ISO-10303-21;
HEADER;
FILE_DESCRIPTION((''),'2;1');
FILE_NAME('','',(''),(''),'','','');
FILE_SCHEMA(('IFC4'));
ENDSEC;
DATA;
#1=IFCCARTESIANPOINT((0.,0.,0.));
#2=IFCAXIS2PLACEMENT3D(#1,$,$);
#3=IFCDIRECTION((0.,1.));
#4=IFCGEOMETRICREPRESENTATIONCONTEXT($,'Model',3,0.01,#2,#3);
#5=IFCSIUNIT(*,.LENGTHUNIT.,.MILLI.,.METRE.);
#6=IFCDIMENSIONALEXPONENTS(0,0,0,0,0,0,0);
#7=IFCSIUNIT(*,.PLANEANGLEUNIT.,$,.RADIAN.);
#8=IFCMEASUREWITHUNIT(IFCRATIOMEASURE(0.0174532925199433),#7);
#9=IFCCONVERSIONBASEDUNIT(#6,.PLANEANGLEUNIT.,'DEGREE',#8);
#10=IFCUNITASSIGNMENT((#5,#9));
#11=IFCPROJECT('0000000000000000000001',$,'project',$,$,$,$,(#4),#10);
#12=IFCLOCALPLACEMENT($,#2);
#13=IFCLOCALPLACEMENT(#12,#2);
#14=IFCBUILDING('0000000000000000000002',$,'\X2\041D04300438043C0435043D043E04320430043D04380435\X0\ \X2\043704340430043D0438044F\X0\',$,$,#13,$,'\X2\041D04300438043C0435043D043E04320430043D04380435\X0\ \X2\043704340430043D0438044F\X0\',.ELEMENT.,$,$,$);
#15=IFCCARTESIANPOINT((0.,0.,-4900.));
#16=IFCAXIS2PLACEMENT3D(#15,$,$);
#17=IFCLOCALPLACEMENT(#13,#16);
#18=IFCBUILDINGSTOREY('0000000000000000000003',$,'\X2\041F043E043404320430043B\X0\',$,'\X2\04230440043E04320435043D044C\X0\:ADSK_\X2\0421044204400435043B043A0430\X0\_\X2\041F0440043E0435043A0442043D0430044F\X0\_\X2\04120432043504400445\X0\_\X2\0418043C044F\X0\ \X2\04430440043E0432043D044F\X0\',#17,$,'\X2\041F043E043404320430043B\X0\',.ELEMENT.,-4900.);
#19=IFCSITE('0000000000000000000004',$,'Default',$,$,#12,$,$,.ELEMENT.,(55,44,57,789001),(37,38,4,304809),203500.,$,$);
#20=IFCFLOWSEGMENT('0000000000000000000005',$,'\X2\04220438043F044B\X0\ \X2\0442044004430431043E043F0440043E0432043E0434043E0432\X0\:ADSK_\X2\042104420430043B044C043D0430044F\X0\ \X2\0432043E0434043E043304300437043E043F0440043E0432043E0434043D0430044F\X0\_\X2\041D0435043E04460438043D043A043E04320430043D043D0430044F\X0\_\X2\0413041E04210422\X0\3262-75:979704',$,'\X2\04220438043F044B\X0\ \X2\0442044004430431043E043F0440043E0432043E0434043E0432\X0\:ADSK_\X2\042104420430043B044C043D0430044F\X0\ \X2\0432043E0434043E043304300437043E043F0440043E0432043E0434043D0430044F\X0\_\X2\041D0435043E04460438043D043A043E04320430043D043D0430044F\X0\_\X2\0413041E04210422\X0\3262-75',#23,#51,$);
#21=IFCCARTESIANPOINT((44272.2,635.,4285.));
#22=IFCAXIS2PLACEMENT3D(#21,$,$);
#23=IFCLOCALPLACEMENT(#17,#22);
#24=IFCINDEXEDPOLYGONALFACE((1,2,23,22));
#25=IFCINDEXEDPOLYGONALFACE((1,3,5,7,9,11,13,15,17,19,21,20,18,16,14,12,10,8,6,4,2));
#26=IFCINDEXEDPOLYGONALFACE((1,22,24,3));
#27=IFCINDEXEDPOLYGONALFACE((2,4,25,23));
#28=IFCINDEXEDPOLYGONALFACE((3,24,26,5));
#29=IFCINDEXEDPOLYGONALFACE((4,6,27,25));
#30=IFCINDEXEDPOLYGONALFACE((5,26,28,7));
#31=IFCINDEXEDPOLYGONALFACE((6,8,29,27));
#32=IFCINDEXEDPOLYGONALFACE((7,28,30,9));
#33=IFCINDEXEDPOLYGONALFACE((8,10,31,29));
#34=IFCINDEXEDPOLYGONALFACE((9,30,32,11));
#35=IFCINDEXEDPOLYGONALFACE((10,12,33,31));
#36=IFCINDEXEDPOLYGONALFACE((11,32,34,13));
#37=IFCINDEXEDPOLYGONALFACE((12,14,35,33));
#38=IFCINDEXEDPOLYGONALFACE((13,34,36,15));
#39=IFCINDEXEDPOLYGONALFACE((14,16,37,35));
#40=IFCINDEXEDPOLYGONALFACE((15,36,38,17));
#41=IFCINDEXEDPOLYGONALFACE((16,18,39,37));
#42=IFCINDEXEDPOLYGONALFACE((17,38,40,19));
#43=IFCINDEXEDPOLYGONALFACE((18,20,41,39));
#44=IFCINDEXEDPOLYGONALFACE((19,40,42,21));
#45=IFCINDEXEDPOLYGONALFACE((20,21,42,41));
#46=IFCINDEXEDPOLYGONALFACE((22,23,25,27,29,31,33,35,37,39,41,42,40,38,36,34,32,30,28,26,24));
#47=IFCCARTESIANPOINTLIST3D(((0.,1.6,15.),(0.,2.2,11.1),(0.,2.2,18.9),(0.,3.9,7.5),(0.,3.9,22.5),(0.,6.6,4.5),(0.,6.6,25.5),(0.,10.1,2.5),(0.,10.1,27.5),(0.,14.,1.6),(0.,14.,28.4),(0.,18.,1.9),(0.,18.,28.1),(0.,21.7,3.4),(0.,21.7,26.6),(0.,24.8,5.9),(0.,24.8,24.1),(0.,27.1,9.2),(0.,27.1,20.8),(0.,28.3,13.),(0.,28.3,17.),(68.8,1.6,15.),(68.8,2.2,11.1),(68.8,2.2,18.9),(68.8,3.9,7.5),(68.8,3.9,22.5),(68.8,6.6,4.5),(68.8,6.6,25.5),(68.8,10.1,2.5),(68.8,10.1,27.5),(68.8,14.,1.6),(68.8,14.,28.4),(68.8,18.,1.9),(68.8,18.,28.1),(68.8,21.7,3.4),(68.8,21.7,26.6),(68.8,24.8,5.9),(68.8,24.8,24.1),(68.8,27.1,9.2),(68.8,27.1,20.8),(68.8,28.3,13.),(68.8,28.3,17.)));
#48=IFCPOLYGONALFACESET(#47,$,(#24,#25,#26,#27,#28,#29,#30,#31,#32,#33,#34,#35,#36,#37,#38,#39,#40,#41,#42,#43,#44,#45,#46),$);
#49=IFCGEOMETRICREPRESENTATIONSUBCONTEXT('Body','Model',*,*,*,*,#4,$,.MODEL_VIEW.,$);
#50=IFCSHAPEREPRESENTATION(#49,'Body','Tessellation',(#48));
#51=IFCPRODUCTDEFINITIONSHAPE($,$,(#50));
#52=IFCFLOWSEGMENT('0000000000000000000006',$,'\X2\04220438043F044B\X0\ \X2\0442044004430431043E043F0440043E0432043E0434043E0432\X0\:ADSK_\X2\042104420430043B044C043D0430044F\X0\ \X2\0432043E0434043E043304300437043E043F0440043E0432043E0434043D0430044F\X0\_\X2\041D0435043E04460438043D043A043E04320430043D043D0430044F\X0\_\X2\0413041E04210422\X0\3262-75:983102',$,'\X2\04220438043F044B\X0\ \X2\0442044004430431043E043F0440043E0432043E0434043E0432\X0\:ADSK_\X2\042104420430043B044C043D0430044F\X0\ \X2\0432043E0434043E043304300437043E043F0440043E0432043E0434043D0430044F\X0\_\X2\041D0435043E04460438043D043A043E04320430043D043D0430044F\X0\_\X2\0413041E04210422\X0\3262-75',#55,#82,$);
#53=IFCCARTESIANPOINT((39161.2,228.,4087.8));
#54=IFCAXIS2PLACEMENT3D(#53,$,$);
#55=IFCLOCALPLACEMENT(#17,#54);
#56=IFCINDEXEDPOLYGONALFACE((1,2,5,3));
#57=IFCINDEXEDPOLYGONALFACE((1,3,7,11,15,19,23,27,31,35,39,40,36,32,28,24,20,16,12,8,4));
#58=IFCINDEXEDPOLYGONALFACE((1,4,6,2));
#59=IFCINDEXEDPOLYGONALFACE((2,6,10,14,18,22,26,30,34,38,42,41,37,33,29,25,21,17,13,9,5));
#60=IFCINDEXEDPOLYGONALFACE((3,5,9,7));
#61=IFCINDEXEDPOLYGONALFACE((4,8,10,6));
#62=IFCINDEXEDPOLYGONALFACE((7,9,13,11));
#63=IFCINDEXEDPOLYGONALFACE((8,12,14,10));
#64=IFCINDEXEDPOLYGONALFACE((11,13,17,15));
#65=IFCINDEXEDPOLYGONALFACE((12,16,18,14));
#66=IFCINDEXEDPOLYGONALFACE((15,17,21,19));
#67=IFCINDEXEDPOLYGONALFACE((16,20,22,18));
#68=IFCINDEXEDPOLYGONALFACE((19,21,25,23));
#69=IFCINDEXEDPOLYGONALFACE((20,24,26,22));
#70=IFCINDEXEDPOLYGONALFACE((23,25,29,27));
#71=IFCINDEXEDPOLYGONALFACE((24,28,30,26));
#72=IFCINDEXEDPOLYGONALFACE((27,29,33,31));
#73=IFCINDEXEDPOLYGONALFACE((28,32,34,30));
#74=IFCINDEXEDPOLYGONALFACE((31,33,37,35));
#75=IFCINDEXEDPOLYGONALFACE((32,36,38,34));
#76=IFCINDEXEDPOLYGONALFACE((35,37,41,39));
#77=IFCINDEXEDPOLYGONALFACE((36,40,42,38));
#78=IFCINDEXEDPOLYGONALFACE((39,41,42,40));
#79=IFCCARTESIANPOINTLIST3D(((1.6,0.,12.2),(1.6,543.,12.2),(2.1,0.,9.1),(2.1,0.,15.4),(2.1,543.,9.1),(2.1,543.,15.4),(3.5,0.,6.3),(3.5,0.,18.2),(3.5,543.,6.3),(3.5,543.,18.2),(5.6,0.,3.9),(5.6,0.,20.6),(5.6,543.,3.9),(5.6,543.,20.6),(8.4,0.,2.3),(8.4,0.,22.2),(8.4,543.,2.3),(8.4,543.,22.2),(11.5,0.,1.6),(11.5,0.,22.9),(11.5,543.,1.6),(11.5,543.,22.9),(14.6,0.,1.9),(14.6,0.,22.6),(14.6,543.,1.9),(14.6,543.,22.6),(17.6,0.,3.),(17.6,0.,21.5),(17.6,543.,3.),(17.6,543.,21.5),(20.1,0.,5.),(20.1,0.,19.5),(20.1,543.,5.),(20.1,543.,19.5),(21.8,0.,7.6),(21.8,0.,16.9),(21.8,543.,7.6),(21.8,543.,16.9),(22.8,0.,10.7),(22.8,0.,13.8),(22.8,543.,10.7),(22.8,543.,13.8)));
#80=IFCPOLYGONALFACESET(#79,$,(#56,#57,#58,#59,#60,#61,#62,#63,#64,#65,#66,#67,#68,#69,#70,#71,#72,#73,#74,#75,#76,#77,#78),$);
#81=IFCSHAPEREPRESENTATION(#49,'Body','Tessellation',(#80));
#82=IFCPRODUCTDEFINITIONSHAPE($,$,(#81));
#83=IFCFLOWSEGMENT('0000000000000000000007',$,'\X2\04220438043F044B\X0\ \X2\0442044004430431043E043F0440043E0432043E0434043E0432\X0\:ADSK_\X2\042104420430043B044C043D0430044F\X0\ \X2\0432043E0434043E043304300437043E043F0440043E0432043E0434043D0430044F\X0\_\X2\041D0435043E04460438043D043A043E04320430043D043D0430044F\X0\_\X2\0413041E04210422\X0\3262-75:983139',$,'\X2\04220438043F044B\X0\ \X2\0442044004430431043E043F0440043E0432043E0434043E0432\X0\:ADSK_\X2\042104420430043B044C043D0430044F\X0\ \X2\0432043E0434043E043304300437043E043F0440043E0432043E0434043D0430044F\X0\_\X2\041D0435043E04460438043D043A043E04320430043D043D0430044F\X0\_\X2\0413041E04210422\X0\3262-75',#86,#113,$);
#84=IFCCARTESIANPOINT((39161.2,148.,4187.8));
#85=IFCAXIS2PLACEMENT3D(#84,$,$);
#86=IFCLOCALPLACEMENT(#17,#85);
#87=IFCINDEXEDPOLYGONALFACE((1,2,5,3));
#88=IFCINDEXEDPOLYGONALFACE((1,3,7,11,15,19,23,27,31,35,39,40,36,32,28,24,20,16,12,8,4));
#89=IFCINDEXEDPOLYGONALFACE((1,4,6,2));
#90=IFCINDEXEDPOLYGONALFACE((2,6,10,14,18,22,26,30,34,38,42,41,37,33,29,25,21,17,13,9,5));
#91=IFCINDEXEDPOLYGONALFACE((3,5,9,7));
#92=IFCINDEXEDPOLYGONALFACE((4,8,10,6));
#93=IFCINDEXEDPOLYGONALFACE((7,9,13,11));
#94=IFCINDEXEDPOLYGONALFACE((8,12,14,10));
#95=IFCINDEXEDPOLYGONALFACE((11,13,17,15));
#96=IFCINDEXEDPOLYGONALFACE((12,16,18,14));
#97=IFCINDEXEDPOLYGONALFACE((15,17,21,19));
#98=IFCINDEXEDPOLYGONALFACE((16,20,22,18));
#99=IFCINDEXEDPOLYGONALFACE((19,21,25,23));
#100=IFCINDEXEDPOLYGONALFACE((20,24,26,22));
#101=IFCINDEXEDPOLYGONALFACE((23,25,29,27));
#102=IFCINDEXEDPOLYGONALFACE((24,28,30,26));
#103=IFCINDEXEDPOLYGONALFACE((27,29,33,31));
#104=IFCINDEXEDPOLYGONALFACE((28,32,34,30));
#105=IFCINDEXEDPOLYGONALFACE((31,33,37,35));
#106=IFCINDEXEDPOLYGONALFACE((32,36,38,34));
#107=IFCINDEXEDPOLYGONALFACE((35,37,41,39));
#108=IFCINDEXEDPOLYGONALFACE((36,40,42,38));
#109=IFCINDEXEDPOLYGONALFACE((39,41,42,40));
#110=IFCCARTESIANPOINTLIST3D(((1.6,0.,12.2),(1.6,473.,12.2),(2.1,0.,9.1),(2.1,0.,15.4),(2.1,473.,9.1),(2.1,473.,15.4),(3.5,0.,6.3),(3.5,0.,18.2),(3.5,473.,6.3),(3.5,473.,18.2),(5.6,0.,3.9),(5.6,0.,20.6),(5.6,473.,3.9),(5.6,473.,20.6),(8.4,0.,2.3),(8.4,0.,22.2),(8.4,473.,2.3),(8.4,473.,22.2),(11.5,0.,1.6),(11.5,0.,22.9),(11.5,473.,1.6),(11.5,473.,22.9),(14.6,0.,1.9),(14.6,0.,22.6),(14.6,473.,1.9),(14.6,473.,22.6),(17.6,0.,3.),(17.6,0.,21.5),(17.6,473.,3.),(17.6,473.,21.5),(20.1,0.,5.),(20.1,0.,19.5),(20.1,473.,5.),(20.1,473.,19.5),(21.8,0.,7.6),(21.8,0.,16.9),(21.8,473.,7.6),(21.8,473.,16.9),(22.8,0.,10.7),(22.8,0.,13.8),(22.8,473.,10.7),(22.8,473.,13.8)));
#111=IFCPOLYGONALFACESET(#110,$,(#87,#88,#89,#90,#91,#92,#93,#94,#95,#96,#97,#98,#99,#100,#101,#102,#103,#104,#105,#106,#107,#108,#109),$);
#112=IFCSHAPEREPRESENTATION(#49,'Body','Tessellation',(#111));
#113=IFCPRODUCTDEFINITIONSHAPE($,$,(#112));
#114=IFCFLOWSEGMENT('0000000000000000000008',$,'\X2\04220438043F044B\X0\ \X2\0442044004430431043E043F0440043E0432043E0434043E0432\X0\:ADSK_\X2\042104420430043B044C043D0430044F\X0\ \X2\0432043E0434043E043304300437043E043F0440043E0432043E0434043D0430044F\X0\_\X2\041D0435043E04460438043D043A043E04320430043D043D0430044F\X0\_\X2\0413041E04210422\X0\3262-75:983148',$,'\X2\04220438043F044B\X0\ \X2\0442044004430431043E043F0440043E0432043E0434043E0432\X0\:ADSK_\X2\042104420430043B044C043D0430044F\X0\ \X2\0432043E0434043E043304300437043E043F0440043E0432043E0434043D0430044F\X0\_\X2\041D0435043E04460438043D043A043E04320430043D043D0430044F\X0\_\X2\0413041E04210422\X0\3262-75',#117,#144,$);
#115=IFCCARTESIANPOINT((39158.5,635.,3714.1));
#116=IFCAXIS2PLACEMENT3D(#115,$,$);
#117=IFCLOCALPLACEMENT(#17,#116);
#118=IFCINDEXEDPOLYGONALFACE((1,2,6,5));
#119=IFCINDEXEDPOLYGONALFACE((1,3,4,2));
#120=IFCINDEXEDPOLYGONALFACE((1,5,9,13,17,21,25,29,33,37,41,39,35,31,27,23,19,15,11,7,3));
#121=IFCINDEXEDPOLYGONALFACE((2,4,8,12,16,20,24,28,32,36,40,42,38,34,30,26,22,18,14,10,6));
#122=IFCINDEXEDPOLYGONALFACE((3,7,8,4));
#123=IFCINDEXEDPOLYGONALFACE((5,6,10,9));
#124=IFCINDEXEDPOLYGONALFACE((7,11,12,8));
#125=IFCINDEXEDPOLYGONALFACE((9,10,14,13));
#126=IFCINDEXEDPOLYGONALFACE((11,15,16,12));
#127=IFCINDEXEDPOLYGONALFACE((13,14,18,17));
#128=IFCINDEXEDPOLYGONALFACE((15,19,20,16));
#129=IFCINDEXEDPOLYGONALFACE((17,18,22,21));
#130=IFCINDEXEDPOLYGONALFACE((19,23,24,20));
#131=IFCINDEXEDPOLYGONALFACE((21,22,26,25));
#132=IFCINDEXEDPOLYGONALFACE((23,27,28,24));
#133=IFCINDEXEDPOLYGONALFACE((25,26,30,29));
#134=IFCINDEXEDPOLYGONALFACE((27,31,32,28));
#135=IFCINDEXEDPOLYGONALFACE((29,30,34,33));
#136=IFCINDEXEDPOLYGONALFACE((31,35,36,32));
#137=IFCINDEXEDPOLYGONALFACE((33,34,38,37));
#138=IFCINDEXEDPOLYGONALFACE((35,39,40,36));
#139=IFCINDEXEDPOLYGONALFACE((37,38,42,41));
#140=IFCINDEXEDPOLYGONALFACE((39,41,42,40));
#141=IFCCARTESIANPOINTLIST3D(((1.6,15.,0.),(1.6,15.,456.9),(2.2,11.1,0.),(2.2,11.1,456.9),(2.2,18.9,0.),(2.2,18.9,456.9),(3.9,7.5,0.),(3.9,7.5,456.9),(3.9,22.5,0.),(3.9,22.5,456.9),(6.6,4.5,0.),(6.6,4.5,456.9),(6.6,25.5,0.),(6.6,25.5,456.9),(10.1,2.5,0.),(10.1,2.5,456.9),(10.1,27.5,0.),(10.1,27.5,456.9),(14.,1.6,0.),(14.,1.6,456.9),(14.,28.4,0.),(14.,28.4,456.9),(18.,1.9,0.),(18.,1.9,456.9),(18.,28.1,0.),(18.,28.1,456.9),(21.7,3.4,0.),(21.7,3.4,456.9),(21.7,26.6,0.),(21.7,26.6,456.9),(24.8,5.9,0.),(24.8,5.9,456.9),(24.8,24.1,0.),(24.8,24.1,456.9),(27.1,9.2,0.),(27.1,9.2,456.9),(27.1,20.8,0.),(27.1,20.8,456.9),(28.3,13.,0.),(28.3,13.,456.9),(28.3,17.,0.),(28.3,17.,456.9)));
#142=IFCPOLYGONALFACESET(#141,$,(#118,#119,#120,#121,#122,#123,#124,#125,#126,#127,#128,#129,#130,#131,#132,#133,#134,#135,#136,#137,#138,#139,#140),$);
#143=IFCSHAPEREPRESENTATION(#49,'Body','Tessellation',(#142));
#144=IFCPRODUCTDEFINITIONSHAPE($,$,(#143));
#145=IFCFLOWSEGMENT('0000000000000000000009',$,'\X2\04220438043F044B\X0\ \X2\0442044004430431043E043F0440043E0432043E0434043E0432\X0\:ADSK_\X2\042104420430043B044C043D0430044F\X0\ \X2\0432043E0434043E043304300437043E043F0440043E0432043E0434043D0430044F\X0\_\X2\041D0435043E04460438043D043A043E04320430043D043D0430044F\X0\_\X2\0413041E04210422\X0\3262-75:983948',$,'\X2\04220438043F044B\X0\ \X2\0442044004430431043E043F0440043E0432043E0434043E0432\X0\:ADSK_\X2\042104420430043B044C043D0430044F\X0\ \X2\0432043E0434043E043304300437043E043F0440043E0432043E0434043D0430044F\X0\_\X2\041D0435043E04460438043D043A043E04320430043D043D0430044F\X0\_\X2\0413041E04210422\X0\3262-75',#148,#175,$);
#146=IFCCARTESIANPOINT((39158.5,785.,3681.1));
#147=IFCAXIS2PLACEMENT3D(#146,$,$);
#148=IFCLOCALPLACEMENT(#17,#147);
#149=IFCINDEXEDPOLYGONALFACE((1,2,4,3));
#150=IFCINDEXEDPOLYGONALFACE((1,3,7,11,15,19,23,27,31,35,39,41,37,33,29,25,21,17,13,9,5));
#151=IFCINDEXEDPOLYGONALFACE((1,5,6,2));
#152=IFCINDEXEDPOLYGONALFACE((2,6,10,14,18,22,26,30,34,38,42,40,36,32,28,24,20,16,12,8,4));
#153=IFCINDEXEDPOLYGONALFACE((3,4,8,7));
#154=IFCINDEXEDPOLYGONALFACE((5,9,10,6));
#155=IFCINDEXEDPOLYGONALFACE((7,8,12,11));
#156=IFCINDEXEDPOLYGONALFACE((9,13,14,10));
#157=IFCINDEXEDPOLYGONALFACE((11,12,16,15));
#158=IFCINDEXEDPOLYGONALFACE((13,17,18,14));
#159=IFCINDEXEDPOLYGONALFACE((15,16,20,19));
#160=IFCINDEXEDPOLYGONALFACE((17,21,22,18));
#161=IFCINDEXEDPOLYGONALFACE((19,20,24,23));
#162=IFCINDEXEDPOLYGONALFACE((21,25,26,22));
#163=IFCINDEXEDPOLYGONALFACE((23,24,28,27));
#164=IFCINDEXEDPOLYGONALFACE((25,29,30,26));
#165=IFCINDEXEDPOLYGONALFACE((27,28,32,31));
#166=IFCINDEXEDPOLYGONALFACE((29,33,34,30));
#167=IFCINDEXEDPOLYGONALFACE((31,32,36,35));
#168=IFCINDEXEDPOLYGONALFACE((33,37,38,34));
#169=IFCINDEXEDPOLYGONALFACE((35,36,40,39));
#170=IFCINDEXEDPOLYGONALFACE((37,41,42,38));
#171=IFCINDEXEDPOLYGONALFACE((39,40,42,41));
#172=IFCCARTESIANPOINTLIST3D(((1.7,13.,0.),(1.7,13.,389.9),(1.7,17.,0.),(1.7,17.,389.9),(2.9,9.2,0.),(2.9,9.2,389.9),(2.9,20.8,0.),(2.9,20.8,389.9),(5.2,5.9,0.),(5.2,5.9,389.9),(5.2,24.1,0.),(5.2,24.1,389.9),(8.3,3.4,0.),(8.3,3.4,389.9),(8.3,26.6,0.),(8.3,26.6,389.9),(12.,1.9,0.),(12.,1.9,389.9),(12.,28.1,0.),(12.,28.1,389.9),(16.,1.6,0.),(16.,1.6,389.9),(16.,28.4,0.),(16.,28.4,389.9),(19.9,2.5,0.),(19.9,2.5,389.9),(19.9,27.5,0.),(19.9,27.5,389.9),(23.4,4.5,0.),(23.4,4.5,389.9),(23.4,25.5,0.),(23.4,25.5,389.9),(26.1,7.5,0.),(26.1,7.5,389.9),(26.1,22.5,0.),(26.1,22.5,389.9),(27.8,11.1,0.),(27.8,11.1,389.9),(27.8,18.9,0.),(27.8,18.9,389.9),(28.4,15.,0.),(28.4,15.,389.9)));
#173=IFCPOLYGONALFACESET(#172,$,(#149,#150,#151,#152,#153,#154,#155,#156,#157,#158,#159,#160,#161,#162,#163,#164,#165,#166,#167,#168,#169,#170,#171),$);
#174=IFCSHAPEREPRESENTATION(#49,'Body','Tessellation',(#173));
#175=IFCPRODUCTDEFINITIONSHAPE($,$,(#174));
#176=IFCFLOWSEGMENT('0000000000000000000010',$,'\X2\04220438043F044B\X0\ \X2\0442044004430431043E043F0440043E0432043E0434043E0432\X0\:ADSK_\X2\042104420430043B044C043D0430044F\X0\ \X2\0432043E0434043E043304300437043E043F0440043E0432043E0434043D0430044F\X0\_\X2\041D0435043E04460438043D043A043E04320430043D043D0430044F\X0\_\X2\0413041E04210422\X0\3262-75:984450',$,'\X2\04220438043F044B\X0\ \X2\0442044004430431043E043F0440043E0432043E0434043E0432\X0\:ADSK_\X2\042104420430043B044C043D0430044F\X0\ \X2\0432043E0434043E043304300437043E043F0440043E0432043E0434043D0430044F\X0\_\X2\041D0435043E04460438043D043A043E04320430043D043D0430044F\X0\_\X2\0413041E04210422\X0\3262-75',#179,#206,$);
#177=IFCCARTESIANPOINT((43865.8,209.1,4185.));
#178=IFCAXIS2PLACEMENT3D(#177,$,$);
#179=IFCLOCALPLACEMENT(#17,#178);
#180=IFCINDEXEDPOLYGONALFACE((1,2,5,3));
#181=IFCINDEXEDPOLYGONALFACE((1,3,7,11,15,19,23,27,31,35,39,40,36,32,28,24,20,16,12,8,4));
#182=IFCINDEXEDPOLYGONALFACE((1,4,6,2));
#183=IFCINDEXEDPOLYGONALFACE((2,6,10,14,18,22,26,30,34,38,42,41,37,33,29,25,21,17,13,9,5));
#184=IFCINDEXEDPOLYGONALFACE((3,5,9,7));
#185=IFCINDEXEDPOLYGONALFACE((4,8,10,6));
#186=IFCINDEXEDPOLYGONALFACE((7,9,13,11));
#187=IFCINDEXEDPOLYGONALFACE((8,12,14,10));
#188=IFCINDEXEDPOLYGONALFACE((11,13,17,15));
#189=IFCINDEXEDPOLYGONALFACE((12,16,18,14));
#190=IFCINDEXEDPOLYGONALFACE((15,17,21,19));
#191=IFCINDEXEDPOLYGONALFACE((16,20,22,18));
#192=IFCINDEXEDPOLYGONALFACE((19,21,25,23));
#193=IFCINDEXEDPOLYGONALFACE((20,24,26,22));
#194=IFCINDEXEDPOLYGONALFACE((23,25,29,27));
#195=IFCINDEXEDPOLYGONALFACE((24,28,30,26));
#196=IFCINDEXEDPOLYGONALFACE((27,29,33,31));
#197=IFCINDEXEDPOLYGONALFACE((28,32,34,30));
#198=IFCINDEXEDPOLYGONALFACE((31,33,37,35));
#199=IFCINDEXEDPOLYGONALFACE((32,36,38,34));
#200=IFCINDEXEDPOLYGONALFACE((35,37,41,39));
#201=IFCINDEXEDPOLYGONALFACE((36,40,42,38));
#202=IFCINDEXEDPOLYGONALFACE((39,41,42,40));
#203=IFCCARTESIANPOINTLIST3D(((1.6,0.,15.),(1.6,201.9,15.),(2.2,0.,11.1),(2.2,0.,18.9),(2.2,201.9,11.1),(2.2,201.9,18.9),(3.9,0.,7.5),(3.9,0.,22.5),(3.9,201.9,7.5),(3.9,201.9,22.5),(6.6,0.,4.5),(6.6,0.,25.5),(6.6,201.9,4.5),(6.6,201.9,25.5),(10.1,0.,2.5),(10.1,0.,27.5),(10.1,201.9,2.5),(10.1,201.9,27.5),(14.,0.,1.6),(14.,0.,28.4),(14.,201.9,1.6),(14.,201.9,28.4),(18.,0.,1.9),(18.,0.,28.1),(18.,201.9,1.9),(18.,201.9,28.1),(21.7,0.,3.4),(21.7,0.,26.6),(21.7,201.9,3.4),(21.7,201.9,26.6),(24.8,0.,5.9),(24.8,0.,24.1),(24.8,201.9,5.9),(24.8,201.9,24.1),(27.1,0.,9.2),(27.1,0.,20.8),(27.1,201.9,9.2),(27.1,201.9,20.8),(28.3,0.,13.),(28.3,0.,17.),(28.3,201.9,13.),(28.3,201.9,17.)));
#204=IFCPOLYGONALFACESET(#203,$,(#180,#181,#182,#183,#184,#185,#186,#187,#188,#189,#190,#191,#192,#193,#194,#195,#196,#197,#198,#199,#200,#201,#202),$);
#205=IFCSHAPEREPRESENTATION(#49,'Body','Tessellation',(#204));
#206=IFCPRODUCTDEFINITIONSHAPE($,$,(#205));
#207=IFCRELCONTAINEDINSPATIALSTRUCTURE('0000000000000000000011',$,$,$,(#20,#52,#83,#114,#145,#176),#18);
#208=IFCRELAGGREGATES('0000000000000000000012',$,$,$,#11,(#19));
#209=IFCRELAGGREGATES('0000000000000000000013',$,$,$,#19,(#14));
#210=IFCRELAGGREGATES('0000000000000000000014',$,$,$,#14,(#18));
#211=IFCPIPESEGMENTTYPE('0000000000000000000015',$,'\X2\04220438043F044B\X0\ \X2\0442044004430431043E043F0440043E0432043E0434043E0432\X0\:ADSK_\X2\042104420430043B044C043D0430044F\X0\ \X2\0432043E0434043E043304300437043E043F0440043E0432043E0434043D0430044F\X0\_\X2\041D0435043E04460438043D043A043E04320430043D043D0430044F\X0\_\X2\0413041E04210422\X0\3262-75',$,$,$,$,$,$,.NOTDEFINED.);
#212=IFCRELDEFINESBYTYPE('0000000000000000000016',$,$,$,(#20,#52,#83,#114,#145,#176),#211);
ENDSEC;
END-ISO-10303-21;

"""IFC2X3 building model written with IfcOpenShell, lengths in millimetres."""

from ifc_helpers import new_model, entity, si_unit, converted_unit, direction, frame, origin, origin_2d_with_axis, place, context, subcontext, project, spatial, circle, extrude, type_object, element, save


model = new_model("IFC2X3")

# Units and contexts
model_context = context("Model", 3, precision=0.01, world=origin(), true_north=direction((0.0, 1.0)))
body_context = subcontext(model_context, "Body", "Model", "MODEL_VIEW")
ifc_project = project(units=[si_unit("LENGTHUNIT", "METRE", prefix="MILLI"), converted_unit("PLANEANGLEUNIT", "DEGREE", entity("IfcRatioMeasure", 0.0174532925199433), si_unit("PLANEANGLEUNIT", "RADIAN"), dimensions=[0, 0, 0, 0, 0, 0, 0])], contexts=[model_context])

# Site, building, storey
site_placement = place(None, origin())
site = spatial("IfcSite", under=ifc_project, at=site_placement, Name="Default", CompositionType="ELEMENT", RefLatitude=(55, 44, 57, 789001), RefLongitude=(37, 38, 4, 304809), RefElevation=203500.0)
building_placement = place(site_placement, origin())
building = spatial("IfcBuilding", under=site, at=building_placement, Name="Наименование здания", LongName="Наименование здания", CompositionType="ELEMENT")
storey_placement = place(building_placement, frame((0.0, 0.0, -4900.0)))
storey = spatial("IfcBuildingStorey", under=building, at=storey_placement, Name="Подвал", ObjectType="Уровень:ADSK_Стрелка_Проектная_Вверх_Имя уровня", LongName="Подвал", CompositionType="ELEMENT", Elevation=-4900.0)

# Flow segments
pipe_segment_type = type_object("IfcPipeSegmentType", Name="Типы трубопроводов:ADSK_Стальная водогазопроводная_Неоцинкованная_ГОСТ3262-75", PredefinedType="NOTDEFINED")
flow_segment_1_placement = place(storey_placement, frame((44272.2, 635.0, 4285.0)))
element("IfcFlowSegment", 1, at=flow_segment_1_placement, inside=storey, type_object=pipe_segment_type, Name="Типы трубопроводов:ADSK_Стальная водогазопроводная_Неоцинкованная_ГОСТ3262-75:979704", ObjectType="Типы трубопроводов:ADSK_Стальная водогазопроводная_Неоцинкованная_ГОСТ3262-75", context=body_context, shape_type="SweptSolid", body=[
    extrude(circle(Radius=13.4, at=origin_2d_with_axis()), frame((0.0, 15.0, 15.0), z_axis=(1.0, 0.0, 0.0), x_axis=(0.0, -1.0, 0.0)), (0.0, 0.0, 1.0), 68.8),
])
flow_segment_2_placement = place(storey_placement, frame((39161.2, 228.0, 4087.8)))
element("IfcFlowSegment", 2, at=flow_segment_2_placement, inside=storey, type_object=pipe_segment_type, Name="Типы трубопроводов:ADSK_Стальная водогазопроводная_Неоцинкованная_ГОСТ3262-75:983102", ObjectType="Типы трубопроводов:ADSK_Стальная водогазопроводная_Неоцинкованная_ГОСТ3262-75", context=body_context, shape_type="SweptSolid", body=[
    extrude(circle(Radius=10.7, at=origin_2d_with_axis()), frame((12.2, 0.0, 12.2), z_axis=(0.0, 1.0, 0.0), x_axis=(-1.0, 0.0, 0.0)), (0.0, 0.0, 1.0), 543.0),
])
flow_segment_3_placement = place(storey_placement, frame((39161.2, 148.0, 4187.8)))
element("IfcFlowSegment", 3, at=flow_segment_3_placement, inside=storey, type_object=pipe_segment_type, Name="Типы трубопроводов:ADSK_Стальная водогазопроводная_Неоцинкованная_ГОСТ3262-75:983139", ObjectType="Типы трубопроводов:ADSK_Стальная водогазопроводная_Неоцинкованная_ГОСТ3262-75", context=body_context, shape_type="SweptSolid", body=[
    extrude(circle(Radius=10.7, at=origin_2d_with_axis()), frame((12.2, 0.0, 12.2), z_axis=(0.0, 1.0, 0.0), x_axis=(-1.0, 0.0, 0.0)), (0.0, 0.0, 1.0), 473.0),
])
flow_segment_4_placement = place(storey_placement, frame((39158.5, 635.0, 3714.1)))
element("IfcFlowSegment", 4, at=flow_segment_4_placement, inside=storey, type_object=pipe_segment_type, Name="Типы трубопроводов:ADSK_Стальная водогазопроводная_Неоцинкованная_ГОСТ3262-75:983148", ObjectType="Типы трубопроводов:ADSK_Стальная водогазопроводная_Неоцинкованная_ГОСТ3262-75", context=body_context, shape_type="SweptSolid", body=[
    extrude(circle(Radius=13.4, at=origin_2d_with_axis()), frame((15.0, 15.0, 0.0), z_axis=(0.0, 0.0, 1.0), x_axis=(-1.0, 0.0, 0.0)), (0.0, 0.0, 1.0), 456.9),
])
flow_segment_5_placement = place(storey_placement, frame((39158.5, 785.0, 3681.1)))
element("IfcFlowSegment", 5, at=flow_segment_5_placement, inside=storey, type_object=pipe_segment_type, Name="Типы трубопроводов:ADSK_Стальная водогазопроводная_Неоцинкованная_ГОСТ3262-75:983948", ObjectType="Типы трубопроводов:ADSK_Стальная водогазопроводная_Неоцинкованная_ГОСТ3262-75", context=body_context, shape_type="SweptSolid", body=[
    extrude(circle(Radius=13.4, at=origin_2d_with_axis()), frame((15.0, 15.0, 0.0)), (0.0, 0.0, 1.0), 389.9),
])
flow_segment_6_placement = place(storey_placement, frame((43865.8, 209.1, 4185.0)))
element("IfcFlowSegment", 6, at=flow_segment_6_placement, inside=storey, type_object=pipe_segment_type, Name="Типы трубопроводов:ADSK_Стальная водогазопроводная_Неоцинкованная_ГОСТ3262-75:984450", ObjectType="Типы трубопроводов:ADSK_Стальная водогазопроводная_Неоцинкованная_ГОСТ3262-75", context=body_context, shape_type="SweptSolid", body=[
    extrude(circle(Radius=13.4, at=origin_2d_with_axis()), frame((15.0, 0.0, 15.0), z_axis=(0.0, 1.0, 0.0), x_axis=(-1.0, 0.0, 0.0)), (0.0, 0.0, 1.0), 201.9),
])

save(model, "model.ifc")
